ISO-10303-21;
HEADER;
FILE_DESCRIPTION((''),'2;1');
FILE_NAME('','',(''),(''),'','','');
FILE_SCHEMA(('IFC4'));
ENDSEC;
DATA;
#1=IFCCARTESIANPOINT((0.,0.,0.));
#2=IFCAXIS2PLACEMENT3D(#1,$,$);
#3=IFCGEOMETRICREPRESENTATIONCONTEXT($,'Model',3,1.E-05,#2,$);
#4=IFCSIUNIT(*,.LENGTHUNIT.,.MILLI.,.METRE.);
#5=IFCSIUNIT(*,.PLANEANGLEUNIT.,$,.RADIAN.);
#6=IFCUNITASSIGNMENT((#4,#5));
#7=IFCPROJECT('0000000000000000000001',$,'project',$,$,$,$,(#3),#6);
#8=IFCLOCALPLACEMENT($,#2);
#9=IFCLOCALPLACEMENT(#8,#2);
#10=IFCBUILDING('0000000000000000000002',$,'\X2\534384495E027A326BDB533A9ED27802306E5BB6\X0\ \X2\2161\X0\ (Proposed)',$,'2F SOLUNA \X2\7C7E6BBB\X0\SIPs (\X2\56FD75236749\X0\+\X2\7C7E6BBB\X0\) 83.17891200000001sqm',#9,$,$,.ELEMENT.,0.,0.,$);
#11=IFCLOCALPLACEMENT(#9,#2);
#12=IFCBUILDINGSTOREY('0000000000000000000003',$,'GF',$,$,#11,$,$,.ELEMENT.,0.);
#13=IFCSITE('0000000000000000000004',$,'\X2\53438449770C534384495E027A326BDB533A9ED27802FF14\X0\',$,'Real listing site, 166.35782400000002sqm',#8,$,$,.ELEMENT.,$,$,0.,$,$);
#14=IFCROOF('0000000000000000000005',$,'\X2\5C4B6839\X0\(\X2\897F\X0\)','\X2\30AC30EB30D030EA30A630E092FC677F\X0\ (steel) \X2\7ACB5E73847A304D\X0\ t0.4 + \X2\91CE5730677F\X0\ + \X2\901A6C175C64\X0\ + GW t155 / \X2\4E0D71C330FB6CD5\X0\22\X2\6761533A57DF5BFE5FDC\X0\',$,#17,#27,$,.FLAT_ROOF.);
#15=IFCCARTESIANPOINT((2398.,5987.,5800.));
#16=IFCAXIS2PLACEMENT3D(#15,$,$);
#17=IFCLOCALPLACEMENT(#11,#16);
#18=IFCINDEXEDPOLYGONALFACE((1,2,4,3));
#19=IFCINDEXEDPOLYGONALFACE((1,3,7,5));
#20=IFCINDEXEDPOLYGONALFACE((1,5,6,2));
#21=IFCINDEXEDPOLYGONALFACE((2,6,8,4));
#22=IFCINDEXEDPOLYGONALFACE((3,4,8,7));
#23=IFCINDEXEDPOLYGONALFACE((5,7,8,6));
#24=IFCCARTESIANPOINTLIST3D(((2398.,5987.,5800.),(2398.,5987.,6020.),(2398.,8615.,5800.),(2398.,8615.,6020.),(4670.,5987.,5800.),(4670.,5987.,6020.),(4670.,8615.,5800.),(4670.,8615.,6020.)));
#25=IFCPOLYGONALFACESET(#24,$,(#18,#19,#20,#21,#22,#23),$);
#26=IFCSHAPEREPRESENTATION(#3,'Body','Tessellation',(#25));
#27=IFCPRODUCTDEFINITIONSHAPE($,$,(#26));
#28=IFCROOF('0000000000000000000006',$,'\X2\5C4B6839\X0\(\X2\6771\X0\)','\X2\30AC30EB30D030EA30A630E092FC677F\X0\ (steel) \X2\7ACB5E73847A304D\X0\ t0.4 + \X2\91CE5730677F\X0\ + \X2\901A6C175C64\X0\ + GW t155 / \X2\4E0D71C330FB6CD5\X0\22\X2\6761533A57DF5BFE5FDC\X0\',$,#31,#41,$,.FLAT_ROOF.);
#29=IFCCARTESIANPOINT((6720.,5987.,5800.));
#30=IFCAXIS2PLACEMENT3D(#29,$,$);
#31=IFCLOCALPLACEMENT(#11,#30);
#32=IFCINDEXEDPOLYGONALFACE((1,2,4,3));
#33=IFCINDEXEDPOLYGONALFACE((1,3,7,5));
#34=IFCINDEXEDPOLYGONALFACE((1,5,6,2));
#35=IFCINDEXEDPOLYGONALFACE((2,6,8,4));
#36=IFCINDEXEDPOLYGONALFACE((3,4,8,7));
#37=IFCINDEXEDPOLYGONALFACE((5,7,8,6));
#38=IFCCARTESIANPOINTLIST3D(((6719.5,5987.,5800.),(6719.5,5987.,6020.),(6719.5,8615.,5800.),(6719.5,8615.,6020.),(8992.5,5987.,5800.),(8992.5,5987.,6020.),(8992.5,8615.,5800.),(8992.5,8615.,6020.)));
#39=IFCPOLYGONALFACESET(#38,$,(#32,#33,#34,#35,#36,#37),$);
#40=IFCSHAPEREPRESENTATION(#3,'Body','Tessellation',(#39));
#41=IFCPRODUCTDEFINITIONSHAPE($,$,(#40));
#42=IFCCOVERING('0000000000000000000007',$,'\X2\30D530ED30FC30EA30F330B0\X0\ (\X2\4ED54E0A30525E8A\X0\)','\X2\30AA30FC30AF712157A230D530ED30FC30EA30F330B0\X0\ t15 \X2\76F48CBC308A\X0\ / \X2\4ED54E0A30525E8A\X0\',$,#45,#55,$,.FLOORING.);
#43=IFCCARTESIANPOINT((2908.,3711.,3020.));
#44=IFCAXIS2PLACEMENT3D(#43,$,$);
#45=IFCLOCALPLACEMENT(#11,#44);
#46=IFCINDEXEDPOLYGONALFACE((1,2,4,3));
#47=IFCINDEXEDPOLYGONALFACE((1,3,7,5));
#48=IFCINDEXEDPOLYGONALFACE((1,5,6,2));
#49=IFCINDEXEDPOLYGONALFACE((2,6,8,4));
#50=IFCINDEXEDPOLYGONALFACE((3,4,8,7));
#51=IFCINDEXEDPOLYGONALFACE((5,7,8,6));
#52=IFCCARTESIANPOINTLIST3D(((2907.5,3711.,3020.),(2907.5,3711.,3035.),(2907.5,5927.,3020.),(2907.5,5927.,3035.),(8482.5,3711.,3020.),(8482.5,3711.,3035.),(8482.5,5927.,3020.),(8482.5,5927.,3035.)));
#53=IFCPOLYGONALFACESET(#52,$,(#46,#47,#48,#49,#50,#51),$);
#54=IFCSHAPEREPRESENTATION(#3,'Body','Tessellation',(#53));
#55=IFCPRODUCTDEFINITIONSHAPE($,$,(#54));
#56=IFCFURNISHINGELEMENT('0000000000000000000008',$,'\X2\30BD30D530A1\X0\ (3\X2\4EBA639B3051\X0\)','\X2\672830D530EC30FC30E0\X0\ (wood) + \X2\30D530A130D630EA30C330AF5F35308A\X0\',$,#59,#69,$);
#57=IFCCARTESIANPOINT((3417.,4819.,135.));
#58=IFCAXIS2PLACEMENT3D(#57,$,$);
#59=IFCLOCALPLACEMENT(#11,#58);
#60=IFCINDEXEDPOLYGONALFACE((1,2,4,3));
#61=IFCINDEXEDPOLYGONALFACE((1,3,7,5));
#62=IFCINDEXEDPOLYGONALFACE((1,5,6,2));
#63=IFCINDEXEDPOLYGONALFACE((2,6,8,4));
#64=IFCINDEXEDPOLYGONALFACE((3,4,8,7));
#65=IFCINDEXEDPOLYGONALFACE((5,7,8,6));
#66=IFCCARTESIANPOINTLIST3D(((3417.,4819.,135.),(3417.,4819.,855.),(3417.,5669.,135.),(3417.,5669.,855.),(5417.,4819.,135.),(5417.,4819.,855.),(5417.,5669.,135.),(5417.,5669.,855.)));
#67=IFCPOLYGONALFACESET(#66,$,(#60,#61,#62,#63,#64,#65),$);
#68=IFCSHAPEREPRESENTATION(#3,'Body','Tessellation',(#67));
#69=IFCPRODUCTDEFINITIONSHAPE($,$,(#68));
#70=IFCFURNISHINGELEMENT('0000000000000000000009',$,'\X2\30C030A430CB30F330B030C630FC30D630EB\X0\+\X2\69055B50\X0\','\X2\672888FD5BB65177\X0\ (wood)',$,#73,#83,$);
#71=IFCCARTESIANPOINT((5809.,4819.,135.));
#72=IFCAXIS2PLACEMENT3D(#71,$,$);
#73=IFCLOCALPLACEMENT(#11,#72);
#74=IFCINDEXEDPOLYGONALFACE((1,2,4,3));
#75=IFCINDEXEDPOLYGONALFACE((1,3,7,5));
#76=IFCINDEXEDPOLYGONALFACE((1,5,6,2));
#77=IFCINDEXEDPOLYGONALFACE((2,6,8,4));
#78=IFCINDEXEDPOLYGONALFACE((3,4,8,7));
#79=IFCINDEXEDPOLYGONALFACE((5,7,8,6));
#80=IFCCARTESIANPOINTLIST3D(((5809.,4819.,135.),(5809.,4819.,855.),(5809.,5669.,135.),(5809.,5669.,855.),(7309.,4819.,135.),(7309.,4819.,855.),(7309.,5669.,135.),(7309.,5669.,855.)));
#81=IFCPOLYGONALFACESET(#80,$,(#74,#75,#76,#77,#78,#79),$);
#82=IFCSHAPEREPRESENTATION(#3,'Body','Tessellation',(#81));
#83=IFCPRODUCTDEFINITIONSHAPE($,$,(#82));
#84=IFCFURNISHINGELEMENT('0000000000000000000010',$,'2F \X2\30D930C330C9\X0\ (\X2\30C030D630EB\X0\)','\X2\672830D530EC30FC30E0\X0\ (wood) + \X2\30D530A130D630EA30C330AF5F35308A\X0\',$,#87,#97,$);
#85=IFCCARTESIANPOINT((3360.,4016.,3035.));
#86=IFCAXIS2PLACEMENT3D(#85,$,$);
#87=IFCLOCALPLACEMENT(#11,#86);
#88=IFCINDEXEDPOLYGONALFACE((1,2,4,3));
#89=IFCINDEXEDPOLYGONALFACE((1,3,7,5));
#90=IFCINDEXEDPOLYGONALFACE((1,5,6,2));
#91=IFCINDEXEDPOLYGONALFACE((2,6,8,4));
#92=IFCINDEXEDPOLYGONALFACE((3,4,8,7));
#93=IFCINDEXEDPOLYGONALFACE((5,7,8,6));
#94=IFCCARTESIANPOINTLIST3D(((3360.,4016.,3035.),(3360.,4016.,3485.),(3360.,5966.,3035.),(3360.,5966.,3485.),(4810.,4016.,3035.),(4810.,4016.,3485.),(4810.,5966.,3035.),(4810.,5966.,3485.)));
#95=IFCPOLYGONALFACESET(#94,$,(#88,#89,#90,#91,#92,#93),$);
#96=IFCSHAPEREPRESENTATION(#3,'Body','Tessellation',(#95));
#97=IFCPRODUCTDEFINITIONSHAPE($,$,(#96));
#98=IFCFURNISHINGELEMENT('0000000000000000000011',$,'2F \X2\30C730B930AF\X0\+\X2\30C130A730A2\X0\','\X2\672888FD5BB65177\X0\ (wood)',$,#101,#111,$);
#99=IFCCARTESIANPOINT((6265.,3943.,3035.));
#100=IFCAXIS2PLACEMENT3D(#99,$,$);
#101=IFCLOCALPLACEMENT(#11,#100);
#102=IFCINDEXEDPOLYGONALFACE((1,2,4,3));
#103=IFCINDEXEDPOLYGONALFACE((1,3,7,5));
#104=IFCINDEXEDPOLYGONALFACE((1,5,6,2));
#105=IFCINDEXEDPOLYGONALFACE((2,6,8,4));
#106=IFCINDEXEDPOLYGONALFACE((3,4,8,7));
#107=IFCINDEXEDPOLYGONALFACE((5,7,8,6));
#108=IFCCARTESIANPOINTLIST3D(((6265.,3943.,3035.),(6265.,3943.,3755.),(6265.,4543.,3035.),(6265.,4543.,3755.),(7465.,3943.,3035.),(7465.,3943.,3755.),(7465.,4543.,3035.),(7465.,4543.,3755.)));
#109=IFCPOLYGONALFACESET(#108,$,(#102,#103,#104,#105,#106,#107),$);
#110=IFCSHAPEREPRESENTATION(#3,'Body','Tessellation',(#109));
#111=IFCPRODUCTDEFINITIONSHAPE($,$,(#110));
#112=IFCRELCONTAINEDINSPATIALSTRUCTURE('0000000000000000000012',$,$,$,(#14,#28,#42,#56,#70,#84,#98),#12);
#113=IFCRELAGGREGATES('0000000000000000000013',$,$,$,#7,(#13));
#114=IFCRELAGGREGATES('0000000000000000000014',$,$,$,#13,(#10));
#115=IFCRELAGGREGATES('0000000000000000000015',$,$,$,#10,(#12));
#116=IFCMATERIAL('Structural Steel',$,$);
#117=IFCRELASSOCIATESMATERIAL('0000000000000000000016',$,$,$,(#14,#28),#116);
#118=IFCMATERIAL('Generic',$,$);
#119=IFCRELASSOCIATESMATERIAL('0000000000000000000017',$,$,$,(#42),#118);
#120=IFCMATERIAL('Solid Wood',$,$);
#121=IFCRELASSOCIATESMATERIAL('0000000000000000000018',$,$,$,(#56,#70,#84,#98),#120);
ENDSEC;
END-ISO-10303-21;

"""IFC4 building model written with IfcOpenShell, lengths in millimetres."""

from ifc_helpers import new_model, si_unit, frame, frame_2d, origin, place, context, project, spatial, rectangle, extrude, material, element, save


model = new_model("IFC4")

# Units and contexts
model_context = context("Model", 3, precision=1e-05, world=origin())
ifc_project = project(units=[si_unit("LENGTHUNIT", "METRE", prefix="MILLI"), si_unit("PLANEANGLEUNIT", "RADIAN")], contexts=[model_context])

# Site, building, storey
site_placement = place(None, origin())
site = spatial("IfcSite", under=ifc_project, at=site_placement, Name="千葉県千葉市稲毛区黒砂４", ObjectType="Real listing site, 166.35782400000002sqm", CompositionType="ELEMENT", RefElevation=0.0)
building_placement = place(site_placement, origin())
building = spatial("IfcBuilding", under=site, at=building_placement, Name="千葉市稲毛区黒砂の家 Ⅱ (Proposed)", ObjectType="2F SOLUNA 籾殻SIPs (国産杉+籾殻) 83.17891200000001sqm", CompositionType="ELEMENT", ElevationOfRefHeight=0.0, ElevationOfTerrain=0.0)
storey_placement = place(building_placement, origin())
storey = spatial("IfcBuildingStorey", under=building, at=storey_placement, Name="GF", CompositionType="ELEMENT", Elevation=0.0)

# Shared definitions
ifc_material_1 = material(Name="Solid Wood")

# Roofs
ifc_material_2 = material(Name="Structural Steel")
roof_1_placement = place(storey_placement, frame((2398.0, 5987.0, 5800.0)))
element("IfcRoof", 1, at=roof_1_placement, inside=storey, material=ifc_material_2, Name="屋根(西)", Description="ガルバリウム鋼板 (steel) 立平葺き t0.4 + 野地板 + 通気層 + GW t155 / 不燃・法22条区域対応", PredefinedType="FLAT_ROOF", context=model_context, shape_type="SweptSolid", body=[
    extrude(rectangle(XDim=2272.0, YDim=2628.0, at=frame_2d((1136.0, 1314.0))), frame((2398.0, 5987.0, 5800.0)), (0.0, 0.0, 1.0), 220.0),
])
roof_2_placement = place(storey_placement, frame((6720.0, 5987.0, 5800.0)))
element("IfcRoof", 2, at=roof_2_placement, inside=storey, material=ifc_material_2, Name="屋根(東)", Description="ガルバリウム鋼板 (steel) 立平葺き t0.4 + 野地板 + 通気層 + GW t155 / 不燃・法22条区域対応", PredefinedType="FLAT_ROOF", context=model_context, shape_type="SweptSolid", body=[
    extrude(rectangle(XDim=2273.0, YDim=2628.0, at=frame_2d((1136.0, 1314.0))), frame((6720.0, 5987.0, 5800.0)), (0.0, 0.0, 1.0), 220.0),
])

# Covering
ifc_material_3 = material(Name="Generic")
covering_placement = place(storey_placement, frame((2908.0, 3711.0, 3020.0)))
element("IfcCovering", 3, at=covering_placement, inside=storey, material=ifc_material_3, Name="フローリング (仕上げ床)", Description="オーク無垢フローリング t15 直貼り / 仕上げ床", PredefinedType="FLOORING", context=model_context, shape_type="SweptSolid", body=[
    extrude(rectangle(XDim=5575.0, YDim=2216.0, at=frame_2d((2787.0, 1108.0))), frame((2908.0, 3711.0, 3020.0)), (0.0, 0.0, 1.0), 15.0),
])

# Furnishing elements
furnishing_1_placement = place(storey_placement, frame((3417.0, 4819.0, 135.0)))
element("IfcFurnishingElement", 4, at=furnishing_1_placement, inside=storey, material=ifc_material_1, Name="ソファ (3人掛け)", Description="木フレーム (wood) + ファブリック張り", context=model_context, shape_type="SweptSolid", body=[
    extrude(rectangle(XDim=2000.0, YDim=850.0, at=frame_2d((1000.0, 425.0))), frame((3417.0, 4819.0, 135.0)), (0.0, 0.0, 1.0), 720.0),
])
furnishing_2_placement = place(storey_placement, frame((5809.0, 4819.0, 135.0)))
element("IfcFurnishingElement", 5, at=furnishing_2_placement, inside=storey, material=ifc_material_1, Name="ダイニングテーブル+椅子", Description="木製家具 (wood)", context=model_context, shape_type="SweptSolid", body=[
    extrude(rectangle(XDim=1500.0, YDim=850.0, at=frame_2d((750.0, 425.0))), frame((5809.0, 4819.0, 135.0)), (0.0, 0.0, 1.0), 720.0),
])
furnishing_3_placement = place(storey_placement, frame((3360.0, 4016.0, 3035.0)))
element("IfcFurnishingElement", 6, at=furnishing_3_placement, inside=storey, material=ifc_material_1, Name="2F ベッド (ダブル)", Description="木フレーム (wood) + ファブリック張り", context=model_context, shape_type="SweptSolid", body=[
    extrude(rectangle(XDim=1450.0, YDim=1950.0, at=frame_2d((725.0, 975.0))), frame((3360.0, 4016.0, 3035.0)), (0.0, 0.0, 1.0), 450.0),
])
furnishing_4_placement = place(storey_placement, frame((6265.0, 3943.0, 3035.0)))
element("IfcFurnishingElement", 7, at=furnishing_4_placement, inside=storey, material=ifc_material_1, Name="2F デスク+チェア", Description="木製家具 (wood)", context=model_context, shape_type="SweptSolid", body=[
    extrude(rectangle(XDim=1200.0, YDim=600.0, at=frame_2d((600.0, 300.0))), frame((6265.0, 3943.0, 3035.0)), (0.0, 0.0, 1.0), 720.0),
])

save(model, "model.ifc")
